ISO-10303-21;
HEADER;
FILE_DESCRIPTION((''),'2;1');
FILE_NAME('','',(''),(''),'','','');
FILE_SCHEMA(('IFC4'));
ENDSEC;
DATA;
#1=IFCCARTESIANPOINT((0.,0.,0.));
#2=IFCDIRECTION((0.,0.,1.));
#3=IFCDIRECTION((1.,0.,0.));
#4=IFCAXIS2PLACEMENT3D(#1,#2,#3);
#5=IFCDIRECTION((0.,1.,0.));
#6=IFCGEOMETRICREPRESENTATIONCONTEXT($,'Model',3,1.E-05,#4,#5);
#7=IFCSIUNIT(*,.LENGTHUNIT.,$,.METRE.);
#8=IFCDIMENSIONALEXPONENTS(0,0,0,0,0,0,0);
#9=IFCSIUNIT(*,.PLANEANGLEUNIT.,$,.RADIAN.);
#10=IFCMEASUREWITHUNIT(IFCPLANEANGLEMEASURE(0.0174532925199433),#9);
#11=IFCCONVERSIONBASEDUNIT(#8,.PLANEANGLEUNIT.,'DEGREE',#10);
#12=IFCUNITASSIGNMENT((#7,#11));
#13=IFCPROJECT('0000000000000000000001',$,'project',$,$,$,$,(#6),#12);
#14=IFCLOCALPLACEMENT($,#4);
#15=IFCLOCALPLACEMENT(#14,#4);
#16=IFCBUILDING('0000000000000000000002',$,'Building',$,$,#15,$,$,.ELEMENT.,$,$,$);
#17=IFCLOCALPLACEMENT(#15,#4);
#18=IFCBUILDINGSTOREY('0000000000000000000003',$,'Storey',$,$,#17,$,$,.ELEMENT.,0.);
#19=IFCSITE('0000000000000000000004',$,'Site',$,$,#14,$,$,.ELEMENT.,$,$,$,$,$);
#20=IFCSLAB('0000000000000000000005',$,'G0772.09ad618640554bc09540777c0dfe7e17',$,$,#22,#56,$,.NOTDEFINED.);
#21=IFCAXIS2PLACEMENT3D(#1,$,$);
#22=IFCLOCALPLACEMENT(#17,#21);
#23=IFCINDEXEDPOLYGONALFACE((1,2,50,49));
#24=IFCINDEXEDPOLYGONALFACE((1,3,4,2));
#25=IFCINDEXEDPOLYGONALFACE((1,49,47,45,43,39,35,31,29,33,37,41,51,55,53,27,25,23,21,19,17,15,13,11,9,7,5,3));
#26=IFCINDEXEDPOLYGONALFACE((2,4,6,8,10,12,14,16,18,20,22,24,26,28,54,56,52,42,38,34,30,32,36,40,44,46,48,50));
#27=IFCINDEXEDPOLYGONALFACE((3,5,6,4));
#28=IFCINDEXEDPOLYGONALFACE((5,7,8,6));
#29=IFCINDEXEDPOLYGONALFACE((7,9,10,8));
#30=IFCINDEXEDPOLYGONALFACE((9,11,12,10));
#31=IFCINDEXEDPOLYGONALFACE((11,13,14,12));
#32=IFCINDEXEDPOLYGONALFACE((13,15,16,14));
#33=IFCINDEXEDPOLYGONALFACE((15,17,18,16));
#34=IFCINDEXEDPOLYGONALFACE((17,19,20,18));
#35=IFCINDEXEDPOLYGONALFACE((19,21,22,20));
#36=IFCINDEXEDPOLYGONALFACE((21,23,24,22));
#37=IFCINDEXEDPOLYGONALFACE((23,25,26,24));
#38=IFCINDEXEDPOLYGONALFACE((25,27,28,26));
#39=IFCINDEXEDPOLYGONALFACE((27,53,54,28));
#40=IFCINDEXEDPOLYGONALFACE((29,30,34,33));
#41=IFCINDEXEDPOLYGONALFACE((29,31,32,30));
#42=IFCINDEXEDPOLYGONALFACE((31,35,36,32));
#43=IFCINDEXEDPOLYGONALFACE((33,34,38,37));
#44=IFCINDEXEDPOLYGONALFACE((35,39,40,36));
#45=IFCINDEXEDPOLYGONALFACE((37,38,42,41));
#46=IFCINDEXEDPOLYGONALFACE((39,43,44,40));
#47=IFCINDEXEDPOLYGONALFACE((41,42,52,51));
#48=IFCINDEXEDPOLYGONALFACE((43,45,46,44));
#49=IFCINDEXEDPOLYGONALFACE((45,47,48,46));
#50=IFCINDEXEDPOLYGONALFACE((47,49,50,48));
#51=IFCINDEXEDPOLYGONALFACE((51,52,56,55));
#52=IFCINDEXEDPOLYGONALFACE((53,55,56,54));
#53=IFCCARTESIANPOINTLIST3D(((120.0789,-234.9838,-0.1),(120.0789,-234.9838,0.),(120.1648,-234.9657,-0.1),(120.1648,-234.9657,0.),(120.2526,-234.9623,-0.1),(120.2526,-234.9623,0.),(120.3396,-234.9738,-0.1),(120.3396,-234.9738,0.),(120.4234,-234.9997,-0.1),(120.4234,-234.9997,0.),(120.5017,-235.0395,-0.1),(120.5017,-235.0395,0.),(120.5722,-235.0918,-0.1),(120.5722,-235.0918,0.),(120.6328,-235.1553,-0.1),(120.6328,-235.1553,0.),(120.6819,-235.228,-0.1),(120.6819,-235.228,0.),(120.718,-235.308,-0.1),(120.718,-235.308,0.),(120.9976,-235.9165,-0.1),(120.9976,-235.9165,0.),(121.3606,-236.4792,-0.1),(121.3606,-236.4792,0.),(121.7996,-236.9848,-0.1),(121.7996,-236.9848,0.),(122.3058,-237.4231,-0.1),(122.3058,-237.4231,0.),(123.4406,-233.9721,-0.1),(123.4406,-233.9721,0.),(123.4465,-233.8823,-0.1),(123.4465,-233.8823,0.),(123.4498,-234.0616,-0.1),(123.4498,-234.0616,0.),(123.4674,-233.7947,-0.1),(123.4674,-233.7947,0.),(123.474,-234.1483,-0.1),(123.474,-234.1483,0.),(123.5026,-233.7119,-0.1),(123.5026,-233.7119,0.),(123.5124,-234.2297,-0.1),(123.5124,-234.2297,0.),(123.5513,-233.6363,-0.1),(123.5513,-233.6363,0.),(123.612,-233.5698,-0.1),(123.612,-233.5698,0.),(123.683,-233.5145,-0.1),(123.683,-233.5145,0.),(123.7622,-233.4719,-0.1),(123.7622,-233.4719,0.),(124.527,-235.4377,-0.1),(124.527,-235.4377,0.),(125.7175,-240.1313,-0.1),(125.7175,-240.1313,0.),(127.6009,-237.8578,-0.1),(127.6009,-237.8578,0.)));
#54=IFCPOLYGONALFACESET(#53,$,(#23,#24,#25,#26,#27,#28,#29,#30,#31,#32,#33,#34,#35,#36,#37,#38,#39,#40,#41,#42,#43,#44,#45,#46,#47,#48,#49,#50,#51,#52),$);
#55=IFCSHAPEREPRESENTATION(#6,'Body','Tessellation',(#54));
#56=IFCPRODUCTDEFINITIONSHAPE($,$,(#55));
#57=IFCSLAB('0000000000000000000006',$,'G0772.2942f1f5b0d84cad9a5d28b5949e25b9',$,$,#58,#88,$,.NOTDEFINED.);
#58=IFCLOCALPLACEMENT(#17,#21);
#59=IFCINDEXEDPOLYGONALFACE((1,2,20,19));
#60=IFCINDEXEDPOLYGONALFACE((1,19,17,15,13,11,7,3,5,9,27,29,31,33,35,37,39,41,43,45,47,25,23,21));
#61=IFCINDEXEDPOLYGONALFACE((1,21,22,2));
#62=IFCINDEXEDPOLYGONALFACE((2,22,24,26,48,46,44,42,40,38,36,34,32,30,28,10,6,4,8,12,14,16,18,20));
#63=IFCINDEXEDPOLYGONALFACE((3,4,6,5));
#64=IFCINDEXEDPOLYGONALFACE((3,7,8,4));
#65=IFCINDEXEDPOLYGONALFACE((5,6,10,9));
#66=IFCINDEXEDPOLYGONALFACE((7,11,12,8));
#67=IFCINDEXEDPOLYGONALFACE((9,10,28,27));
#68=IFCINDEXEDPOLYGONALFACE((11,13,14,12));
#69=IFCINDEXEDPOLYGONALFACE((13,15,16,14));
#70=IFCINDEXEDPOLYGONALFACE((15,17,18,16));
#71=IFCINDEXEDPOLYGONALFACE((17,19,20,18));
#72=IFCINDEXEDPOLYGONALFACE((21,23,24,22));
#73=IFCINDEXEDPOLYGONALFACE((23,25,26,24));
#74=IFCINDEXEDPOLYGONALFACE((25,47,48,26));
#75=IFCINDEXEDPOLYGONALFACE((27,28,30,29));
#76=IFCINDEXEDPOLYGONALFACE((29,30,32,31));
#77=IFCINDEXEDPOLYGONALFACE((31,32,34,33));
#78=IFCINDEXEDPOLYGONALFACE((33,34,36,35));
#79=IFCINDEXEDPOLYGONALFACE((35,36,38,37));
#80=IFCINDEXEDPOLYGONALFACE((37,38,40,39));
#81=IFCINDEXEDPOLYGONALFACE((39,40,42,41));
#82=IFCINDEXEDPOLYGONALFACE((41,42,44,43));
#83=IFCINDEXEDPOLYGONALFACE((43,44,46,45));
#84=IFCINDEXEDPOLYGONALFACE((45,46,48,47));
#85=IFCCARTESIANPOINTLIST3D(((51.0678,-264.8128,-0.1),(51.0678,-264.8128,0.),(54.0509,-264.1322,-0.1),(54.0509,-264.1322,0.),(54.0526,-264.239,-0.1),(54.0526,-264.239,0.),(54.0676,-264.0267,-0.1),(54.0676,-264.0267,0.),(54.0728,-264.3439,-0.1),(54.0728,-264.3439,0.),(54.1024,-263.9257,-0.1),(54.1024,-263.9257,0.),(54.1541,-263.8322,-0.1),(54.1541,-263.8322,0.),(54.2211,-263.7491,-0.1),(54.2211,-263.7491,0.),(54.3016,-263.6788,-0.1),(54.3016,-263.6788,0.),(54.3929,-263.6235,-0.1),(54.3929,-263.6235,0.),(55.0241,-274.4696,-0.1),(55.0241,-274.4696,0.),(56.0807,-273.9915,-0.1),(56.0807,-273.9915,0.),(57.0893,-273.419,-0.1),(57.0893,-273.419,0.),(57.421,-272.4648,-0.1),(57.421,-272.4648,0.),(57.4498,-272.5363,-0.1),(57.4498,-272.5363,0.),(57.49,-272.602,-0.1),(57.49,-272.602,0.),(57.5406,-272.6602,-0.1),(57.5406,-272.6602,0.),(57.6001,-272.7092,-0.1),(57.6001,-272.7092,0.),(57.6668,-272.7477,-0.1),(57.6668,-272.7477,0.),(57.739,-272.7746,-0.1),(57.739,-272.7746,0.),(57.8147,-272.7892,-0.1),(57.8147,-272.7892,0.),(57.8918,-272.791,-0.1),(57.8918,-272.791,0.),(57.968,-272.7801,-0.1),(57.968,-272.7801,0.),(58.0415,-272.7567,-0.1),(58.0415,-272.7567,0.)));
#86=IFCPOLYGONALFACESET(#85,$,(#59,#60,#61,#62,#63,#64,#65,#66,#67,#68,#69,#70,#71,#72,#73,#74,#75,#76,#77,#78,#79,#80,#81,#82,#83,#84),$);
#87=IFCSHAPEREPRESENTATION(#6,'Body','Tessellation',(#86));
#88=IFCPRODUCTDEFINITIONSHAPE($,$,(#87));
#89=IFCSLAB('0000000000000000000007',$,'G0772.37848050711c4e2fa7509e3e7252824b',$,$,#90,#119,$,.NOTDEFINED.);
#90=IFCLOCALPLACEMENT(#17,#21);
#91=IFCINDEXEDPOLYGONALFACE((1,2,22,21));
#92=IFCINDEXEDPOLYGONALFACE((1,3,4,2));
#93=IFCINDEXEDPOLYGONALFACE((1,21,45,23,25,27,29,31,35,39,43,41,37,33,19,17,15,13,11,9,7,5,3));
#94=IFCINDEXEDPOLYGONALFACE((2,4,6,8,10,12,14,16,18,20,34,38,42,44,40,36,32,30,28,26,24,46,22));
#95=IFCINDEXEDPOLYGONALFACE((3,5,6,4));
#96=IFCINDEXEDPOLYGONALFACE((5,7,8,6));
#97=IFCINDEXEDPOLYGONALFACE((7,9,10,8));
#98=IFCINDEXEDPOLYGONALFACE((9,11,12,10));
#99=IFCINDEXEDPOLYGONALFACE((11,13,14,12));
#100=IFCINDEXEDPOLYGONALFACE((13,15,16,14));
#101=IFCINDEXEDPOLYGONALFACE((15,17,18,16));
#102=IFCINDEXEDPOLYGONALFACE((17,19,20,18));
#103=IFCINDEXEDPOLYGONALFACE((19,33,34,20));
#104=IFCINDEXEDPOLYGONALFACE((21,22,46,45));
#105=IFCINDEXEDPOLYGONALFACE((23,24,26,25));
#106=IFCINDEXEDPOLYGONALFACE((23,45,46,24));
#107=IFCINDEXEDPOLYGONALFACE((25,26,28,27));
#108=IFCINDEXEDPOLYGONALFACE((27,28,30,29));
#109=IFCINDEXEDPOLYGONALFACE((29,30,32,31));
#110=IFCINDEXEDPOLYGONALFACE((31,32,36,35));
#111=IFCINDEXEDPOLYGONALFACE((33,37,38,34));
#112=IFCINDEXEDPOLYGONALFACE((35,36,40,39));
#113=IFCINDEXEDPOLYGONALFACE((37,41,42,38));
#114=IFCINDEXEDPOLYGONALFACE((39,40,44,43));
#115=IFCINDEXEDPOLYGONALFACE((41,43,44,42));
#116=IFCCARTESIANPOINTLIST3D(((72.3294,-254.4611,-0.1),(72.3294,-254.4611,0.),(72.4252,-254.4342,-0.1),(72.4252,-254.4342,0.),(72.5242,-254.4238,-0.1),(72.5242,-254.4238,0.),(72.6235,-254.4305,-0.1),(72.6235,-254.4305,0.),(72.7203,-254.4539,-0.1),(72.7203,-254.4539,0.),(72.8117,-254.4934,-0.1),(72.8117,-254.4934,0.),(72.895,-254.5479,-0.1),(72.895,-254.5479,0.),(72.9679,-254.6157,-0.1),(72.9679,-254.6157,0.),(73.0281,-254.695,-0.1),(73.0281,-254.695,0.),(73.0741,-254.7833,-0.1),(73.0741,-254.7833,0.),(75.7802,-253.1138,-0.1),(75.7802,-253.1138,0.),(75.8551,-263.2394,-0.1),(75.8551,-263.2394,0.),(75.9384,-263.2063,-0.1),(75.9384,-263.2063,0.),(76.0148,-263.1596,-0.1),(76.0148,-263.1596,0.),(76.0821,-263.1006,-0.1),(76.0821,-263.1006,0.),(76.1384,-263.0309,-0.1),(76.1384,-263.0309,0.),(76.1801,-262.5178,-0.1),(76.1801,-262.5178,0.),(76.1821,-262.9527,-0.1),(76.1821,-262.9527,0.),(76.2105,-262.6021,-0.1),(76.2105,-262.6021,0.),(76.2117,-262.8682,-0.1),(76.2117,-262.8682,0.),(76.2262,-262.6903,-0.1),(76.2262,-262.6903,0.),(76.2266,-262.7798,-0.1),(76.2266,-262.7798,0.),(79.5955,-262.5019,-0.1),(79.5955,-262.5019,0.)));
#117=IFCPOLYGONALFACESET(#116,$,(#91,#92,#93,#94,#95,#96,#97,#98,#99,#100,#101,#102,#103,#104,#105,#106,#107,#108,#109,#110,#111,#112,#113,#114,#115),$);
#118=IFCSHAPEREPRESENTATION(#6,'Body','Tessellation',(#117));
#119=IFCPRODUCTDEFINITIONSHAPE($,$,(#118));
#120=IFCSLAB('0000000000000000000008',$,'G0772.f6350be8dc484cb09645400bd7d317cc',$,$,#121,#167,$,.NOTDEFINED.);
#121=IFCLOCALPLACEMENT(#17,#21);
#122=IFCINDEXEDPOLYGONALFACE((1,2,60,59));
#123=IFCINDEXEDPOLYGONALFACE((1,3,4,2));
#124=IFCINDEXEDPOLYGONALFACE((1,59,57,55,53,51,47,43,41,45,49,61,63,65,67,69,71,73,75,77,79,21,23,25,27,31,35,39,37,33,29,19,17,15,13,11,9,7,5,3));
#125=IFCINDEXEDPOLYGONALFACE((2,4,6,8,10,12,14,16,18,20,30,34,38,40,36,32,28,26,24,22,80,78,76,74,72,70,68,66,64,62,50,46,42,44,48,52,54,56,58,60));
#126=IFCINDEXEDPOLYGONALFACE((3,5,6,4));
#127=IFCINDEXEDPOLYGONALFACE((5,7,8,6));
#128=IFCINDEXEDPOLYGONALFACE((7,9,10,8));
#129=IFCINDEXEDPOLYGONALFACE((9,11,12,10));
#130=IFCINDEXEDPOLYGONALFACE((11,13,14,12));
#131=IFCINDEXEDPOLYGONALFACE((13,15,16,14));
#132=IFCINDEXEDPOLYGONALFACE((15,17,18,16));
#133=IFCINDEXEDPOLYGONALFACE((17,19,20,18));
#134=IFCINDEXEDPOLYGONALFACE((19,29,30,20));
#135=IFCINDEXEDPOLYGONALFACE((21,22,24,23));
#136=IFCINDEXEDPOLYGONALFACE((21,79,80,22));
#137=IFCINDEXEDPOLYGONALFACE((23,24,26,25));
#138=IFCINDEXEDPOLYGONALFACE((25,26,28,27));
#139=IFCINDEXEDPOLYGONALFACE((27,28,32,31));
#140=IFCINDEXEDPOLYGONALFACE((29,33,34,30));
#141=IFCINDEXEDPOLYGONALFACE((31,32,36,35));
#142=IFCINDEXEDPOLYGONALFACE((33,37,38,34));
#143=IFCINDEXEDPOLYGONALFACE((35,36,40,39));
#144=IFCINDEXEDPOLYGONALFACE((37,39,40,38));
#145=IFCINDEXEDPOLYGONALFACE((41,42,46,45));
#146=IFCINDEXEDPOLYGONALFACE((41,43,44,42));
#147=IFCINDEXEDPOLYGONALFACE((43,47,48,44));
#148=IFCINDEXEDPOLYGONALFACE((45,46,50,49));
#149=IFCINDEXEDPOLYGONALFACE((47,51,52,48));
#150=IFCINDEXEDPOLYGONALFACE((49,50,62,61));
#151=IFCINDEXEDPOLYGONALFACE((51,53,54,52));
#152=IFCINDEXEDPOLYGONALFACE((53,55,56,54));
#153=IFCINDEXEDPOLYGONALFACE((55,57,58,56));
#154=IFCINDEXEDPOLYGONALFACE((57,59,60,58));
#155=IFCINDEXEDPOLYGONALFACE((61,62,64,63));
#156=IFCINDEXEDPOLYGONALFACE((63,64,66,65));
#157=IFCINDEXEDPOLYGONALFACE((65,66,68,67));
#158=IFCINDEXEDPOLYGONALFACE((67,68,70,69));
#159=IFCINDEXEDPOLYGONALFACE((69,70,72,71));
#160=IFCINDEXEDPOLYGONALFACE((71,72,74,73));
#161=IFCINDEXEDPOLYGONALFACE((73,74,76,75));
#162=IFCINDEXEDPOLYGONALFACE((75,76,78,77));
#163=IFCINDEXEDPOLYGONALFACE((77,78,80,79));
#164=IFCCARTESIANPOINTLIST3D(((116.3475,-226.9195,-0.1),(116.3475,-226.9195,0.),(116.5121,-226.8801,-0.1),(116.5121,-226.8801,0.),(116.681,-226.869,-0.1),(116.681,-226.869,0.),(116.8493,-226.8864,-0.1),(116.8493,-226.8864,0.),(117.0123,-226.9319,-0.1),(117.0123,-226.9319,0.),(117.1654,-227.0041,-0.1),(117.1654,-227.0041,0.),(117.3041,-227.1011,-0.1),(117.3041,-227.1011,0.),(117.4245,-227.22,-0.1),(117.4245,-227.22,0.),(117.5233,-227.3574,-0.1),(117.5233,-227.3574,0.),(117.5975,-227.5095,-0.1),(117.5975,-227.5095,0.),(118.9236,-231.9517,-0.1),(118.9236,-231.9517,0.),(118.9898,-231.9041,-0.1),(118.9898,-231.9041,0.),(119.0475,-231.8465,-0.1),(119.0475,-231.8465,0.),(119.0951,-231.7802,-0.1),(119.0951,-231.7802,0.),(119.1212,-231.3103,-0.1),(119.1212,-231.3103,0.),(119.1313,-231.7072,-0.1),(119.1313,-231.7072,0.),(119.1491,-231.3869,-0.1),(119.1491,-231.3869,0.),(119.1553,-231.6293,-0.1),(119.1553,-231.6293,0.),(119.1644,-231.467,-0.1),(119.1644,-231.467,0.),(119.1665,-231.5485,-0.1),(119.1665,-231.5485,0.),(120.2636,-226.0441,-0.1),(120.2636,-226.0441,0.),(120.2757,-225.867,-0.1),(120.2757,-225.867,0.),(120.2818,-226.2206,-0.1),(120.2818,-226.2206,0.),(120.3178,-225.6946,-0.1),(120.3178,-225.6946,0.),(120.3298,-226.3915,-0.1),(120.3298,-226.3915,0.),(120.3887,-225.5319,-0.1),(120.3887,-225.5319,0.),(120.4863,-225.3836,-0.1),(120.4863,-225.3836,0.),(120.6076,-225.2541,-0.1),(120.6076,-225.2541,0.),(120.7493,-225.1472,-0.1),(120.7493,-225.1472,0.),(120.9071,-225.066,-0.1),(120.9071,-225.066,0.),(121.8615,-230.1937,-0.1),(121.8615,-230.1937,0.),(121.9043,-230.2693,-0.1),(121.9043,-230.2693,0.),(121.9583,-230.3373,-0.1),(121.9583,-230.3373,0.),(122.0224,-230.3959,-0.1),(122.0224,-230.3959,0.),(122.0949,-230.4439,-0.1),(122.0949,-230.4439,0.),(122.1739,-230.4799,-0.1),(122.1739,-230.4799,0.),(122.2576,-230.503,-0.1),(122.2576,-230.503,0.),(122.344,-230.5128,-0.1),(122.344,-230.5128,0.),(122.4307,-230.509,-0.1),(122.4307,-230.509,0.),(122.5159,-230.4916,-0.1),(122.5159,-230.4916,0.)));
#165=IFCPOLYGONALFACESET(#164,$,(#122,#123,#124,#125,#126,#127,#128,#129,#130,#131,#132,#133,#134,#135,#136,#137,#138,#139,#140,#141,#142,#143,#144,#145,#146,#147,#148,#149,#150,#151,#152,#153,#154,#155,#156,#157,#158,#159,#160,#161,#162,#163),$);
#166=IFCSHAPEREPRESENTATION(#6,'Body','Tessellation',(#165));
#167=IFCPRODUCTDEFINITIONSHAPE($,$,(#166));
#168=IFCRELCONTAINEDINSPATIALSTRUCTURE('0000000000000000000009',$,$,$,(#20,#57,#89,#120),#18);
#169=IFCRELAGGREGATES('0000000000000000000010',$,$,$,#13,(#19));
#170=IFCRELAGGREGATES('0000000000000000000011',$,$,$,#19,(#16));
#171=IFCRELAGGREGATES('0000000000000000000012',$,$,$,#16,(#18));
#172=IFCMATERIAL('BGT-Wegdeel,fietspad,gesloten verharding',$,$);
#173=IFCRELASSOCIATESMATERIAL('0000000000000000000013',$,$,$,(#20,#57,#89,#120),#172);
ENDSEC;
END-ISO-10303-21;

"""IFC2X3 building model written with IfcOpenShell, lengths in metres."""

from ifc_helpers import new_model, entity, si_unit, converted_unit, direction, frame, origin_with_axes, place, context, project, spatial, polyline, outline, extrude, material, element, save


model = new_model("IFC2X3")

# Units and contexts
model_context = context("Model", 3, precision=1e-05, world=origin_with_axes(), true_north=direction((0.0, 1.0, 0.0)))
ifc_project = project(units=[si_unit("LENGTHUNIT", "METRE"), converted_unit("PLANEANGLEUNIT", "DEGREE", entity("IfcPlaneAngleMeasure", 0.0174532925199433), si_unit("PLANEANGLEUNIT", "RADIAN"), dimensions=[0, 0, 0, 0, 0, 0, 0])], contexts=[model_context])

# Site, building, storey
site_placement = place(None, origin_with_axes())
site = spatial("IfcSite", under=ifc_project, at=site_placement, Name="Site", CompositionType="ELEMENT")
building_placement = place(site_placement, origin_with_axes())
building = spatial("IfcBuilding", under=site, at=building_placement, Name="Building", CompositionType="ELEMENT")
storey_placement = place(building_placement, origin_with_axes())
storey = spatial("IfcBuildingStorey", under=building, at=storey_placement, Name="Storey", CompositionType="ELEMENT", Elevation=0.0)

# Slabs
ifc_material_1 = material(Name="BGT-Wegdeel,fietspad,gesloten verharding")
slab_1_placement = place(storey_placement, frame((0.0, 0.0, -0.1), z_axis=(0.0, 0.0, 1.0), x_axis=(1.0, 0.0, 0.0)))
element("IfcSlab", 1, at=slab_1_placement, inside=storey, material=ifc_material_1, Name="G0772.09ad618640554bc09540777c0dfe7e17", PredefinedType="NOTDEFINED", context=model_context, shape_type="SweptSolid", body=[
    extrude(outline(polyline([(122.3058, -237.4231), (121.7996, -236.9848), (121.3606, -236.4792), (120.9976, -235.9165), (120.718, -235.308), (120.6819, -235.228), (120.6328, -235.1553), (120.5722, -235.0918), (120.5017, -235.0395), (120.4234, -234.9997), (120.3396, -234.9738), (120.2526, -234.9623), (120.1648, -234.9657), (120.0789, -234.9838), (123.7622, -233.4719), (123.683, -233.5145), (123.612, -233.5698), (123.5513, -233.6363), (123.5026, -233.7119), (123.4674, -233.7947), (123.4465, -233.8823), (123.4406, -233.9721), (123.4498, -234.0616), (123.474, -234.1483), (123.5124, -234.2297), (124.527, -235.4377), (127.6009, -237.8578), (125.7175, -240.1313), (122.3058, -237.4231)])), origin_with_axes(), (0.0, 0.0, 1.0), 0.1),
])
slab_2_placement = place(storey_placement, frame((0.0, 0.0, -0.1), z_axis=(0.0, 0.0, 1.0), x_axis=(1.0, 0.0, 0.0)))
element("IfcSlab", 2, at=slab_2_placement, inside=storey, material=ifc_material_1, Name="G0772.2942f1f5b0d84cad9a5d28b5949e25b9", PredefinedType="NOTDEFINED", context=model_context, shape_type="SweptSolid", body=[
    extrude(outline(polyline([(57.421, -272.4648), (57.4498, -272.5363), (57.49, -272.602), (57.5406, -272.6602), (57.6001, -272.7092), (57.6668, -272.7477), (57.739, -272.7746), (57.8147, -272.7892), (57.8918, -272.791), (57.968, -272.7801), (58.0415, -272.7567), (57.0893, -273.419), (56.0807, -273.9915), (55.0241, -274.4696), (51.0678, -264.8128), (54.3929, -263.6235), (54.3016, -263.6788), (54.2211, -263.7491), (54.1541, -263.8322), (54.1024, -263.9257), (54.0676, -264.0267), (54.0509, -264.1322), (54.0526, -264.239), (54.0728, -264.3439), (57.421, -272.4648)])), origin_with_axes(), (0.0, 0.0, 1.0), 0.1),
])
slab_3_placement = place(storey_placement, frame((0.0, 0.0, -0.1), z_axis=(0.0, 0.0, 1.0), x_axis=(1.0, 0.0, 0.0)))
element("IfcSlab", 3, at=slab_3_placement, inside=storey, material=ifc_material_1, Name="G0772.37848050711c4e2fa7509e3e7252824b", PredefinedType="NOTDEFINED", context=model_context, shape_type="SweptSolid", body=[
    extrude(outline(polyline([(79.5955, -262.5019), (75.8551, -263.2394), (75.9384, -263.2063), (76.0148, -263.1596), (76.0821, -263.1006), (76.1384, -263.0309), (76.1821, -262.9527), (76.2117, -262.8682), (76.2266, -262.7798), (76.2262, -262.6903), (76.2105, -262.6021), (76.1801, -262.5178), (73.0741, -254.7833), (73.0281, -254.695), (72.9679, -254.6157), (72.895, -254.5479), (72.8117, -254.4934), (72.7203, -254.4539), (72.6235, -254.4305), (72.5242, -254.4238), (72.4252, -254.4342), (72.3294, -254.4611), (75.7802, -253.1138), (79.5955, -262.5019)])), origin_with_axes(), (0.0, 0.0, 1.0), 0.1),
])
slab_4_placement = place(storey_placement, frame((0.0, 0.0, -0.1), z_axis=(0.0, 0.0, 1.0), x_axis=(1.0, 0.0, 0.0)))
element("IfcSlab", 4, at=slab_4_placement, inside=storey, material=ifc_material_1, Name="G0772.f6350be8dc484cb09645400bd7d317cc", PredefinedType="NOTDEFINED", context=model_context, shape_type="SweptSolid", body=[
    extrude(outline(polyline([(121.8615, -230.1937), (121.9043, -230.2693), (121.9583, -230.3373), (122.0224, -230.3959), (122.0949, -230.4439), (122.1739, -230.4799), (122.2576, -230.503), (122.344, -230.5128), (122.4307, -230.509), (122.5159, -230.4916), (118.9236, -231.9517), (118.9898, -231.9041), (119.0475, -231.8465), (119.0951, -231.7802), (119.1313, -231.7072), (119.1553, -231.6293), (119.1665, -231.5485), (119.1644, -231.467), (119.1491, -231.3869), (119.1212, -231.3103), (117.5975, -227.5095), (117.5233, -227.3574), (117.4245, -227.22), (117.3041, -227.1011), (117.1654, -227.0041), (117.0123, -226.9319), (116.8493, -226.8864), (116.681, -226.869), (116.5121, -226.8801), (116.3475, -226.9195), (120.9071, -225.066), (120.7493, -225.1472), (120.6076, -225.2541), (120.4863, -225.3836), (120.3887, -225.5319), (120.3178, -225.6946), (120.2757, -225.867), (120.2636, -226.0441), (120.2818, -226.2206), (120.3298, -226.3915), (121.8615, -230.1937)])), origin_with_axes(), (0.0, 0.0, 1.0), 0.1),
])

save(model, "model.ifc")
